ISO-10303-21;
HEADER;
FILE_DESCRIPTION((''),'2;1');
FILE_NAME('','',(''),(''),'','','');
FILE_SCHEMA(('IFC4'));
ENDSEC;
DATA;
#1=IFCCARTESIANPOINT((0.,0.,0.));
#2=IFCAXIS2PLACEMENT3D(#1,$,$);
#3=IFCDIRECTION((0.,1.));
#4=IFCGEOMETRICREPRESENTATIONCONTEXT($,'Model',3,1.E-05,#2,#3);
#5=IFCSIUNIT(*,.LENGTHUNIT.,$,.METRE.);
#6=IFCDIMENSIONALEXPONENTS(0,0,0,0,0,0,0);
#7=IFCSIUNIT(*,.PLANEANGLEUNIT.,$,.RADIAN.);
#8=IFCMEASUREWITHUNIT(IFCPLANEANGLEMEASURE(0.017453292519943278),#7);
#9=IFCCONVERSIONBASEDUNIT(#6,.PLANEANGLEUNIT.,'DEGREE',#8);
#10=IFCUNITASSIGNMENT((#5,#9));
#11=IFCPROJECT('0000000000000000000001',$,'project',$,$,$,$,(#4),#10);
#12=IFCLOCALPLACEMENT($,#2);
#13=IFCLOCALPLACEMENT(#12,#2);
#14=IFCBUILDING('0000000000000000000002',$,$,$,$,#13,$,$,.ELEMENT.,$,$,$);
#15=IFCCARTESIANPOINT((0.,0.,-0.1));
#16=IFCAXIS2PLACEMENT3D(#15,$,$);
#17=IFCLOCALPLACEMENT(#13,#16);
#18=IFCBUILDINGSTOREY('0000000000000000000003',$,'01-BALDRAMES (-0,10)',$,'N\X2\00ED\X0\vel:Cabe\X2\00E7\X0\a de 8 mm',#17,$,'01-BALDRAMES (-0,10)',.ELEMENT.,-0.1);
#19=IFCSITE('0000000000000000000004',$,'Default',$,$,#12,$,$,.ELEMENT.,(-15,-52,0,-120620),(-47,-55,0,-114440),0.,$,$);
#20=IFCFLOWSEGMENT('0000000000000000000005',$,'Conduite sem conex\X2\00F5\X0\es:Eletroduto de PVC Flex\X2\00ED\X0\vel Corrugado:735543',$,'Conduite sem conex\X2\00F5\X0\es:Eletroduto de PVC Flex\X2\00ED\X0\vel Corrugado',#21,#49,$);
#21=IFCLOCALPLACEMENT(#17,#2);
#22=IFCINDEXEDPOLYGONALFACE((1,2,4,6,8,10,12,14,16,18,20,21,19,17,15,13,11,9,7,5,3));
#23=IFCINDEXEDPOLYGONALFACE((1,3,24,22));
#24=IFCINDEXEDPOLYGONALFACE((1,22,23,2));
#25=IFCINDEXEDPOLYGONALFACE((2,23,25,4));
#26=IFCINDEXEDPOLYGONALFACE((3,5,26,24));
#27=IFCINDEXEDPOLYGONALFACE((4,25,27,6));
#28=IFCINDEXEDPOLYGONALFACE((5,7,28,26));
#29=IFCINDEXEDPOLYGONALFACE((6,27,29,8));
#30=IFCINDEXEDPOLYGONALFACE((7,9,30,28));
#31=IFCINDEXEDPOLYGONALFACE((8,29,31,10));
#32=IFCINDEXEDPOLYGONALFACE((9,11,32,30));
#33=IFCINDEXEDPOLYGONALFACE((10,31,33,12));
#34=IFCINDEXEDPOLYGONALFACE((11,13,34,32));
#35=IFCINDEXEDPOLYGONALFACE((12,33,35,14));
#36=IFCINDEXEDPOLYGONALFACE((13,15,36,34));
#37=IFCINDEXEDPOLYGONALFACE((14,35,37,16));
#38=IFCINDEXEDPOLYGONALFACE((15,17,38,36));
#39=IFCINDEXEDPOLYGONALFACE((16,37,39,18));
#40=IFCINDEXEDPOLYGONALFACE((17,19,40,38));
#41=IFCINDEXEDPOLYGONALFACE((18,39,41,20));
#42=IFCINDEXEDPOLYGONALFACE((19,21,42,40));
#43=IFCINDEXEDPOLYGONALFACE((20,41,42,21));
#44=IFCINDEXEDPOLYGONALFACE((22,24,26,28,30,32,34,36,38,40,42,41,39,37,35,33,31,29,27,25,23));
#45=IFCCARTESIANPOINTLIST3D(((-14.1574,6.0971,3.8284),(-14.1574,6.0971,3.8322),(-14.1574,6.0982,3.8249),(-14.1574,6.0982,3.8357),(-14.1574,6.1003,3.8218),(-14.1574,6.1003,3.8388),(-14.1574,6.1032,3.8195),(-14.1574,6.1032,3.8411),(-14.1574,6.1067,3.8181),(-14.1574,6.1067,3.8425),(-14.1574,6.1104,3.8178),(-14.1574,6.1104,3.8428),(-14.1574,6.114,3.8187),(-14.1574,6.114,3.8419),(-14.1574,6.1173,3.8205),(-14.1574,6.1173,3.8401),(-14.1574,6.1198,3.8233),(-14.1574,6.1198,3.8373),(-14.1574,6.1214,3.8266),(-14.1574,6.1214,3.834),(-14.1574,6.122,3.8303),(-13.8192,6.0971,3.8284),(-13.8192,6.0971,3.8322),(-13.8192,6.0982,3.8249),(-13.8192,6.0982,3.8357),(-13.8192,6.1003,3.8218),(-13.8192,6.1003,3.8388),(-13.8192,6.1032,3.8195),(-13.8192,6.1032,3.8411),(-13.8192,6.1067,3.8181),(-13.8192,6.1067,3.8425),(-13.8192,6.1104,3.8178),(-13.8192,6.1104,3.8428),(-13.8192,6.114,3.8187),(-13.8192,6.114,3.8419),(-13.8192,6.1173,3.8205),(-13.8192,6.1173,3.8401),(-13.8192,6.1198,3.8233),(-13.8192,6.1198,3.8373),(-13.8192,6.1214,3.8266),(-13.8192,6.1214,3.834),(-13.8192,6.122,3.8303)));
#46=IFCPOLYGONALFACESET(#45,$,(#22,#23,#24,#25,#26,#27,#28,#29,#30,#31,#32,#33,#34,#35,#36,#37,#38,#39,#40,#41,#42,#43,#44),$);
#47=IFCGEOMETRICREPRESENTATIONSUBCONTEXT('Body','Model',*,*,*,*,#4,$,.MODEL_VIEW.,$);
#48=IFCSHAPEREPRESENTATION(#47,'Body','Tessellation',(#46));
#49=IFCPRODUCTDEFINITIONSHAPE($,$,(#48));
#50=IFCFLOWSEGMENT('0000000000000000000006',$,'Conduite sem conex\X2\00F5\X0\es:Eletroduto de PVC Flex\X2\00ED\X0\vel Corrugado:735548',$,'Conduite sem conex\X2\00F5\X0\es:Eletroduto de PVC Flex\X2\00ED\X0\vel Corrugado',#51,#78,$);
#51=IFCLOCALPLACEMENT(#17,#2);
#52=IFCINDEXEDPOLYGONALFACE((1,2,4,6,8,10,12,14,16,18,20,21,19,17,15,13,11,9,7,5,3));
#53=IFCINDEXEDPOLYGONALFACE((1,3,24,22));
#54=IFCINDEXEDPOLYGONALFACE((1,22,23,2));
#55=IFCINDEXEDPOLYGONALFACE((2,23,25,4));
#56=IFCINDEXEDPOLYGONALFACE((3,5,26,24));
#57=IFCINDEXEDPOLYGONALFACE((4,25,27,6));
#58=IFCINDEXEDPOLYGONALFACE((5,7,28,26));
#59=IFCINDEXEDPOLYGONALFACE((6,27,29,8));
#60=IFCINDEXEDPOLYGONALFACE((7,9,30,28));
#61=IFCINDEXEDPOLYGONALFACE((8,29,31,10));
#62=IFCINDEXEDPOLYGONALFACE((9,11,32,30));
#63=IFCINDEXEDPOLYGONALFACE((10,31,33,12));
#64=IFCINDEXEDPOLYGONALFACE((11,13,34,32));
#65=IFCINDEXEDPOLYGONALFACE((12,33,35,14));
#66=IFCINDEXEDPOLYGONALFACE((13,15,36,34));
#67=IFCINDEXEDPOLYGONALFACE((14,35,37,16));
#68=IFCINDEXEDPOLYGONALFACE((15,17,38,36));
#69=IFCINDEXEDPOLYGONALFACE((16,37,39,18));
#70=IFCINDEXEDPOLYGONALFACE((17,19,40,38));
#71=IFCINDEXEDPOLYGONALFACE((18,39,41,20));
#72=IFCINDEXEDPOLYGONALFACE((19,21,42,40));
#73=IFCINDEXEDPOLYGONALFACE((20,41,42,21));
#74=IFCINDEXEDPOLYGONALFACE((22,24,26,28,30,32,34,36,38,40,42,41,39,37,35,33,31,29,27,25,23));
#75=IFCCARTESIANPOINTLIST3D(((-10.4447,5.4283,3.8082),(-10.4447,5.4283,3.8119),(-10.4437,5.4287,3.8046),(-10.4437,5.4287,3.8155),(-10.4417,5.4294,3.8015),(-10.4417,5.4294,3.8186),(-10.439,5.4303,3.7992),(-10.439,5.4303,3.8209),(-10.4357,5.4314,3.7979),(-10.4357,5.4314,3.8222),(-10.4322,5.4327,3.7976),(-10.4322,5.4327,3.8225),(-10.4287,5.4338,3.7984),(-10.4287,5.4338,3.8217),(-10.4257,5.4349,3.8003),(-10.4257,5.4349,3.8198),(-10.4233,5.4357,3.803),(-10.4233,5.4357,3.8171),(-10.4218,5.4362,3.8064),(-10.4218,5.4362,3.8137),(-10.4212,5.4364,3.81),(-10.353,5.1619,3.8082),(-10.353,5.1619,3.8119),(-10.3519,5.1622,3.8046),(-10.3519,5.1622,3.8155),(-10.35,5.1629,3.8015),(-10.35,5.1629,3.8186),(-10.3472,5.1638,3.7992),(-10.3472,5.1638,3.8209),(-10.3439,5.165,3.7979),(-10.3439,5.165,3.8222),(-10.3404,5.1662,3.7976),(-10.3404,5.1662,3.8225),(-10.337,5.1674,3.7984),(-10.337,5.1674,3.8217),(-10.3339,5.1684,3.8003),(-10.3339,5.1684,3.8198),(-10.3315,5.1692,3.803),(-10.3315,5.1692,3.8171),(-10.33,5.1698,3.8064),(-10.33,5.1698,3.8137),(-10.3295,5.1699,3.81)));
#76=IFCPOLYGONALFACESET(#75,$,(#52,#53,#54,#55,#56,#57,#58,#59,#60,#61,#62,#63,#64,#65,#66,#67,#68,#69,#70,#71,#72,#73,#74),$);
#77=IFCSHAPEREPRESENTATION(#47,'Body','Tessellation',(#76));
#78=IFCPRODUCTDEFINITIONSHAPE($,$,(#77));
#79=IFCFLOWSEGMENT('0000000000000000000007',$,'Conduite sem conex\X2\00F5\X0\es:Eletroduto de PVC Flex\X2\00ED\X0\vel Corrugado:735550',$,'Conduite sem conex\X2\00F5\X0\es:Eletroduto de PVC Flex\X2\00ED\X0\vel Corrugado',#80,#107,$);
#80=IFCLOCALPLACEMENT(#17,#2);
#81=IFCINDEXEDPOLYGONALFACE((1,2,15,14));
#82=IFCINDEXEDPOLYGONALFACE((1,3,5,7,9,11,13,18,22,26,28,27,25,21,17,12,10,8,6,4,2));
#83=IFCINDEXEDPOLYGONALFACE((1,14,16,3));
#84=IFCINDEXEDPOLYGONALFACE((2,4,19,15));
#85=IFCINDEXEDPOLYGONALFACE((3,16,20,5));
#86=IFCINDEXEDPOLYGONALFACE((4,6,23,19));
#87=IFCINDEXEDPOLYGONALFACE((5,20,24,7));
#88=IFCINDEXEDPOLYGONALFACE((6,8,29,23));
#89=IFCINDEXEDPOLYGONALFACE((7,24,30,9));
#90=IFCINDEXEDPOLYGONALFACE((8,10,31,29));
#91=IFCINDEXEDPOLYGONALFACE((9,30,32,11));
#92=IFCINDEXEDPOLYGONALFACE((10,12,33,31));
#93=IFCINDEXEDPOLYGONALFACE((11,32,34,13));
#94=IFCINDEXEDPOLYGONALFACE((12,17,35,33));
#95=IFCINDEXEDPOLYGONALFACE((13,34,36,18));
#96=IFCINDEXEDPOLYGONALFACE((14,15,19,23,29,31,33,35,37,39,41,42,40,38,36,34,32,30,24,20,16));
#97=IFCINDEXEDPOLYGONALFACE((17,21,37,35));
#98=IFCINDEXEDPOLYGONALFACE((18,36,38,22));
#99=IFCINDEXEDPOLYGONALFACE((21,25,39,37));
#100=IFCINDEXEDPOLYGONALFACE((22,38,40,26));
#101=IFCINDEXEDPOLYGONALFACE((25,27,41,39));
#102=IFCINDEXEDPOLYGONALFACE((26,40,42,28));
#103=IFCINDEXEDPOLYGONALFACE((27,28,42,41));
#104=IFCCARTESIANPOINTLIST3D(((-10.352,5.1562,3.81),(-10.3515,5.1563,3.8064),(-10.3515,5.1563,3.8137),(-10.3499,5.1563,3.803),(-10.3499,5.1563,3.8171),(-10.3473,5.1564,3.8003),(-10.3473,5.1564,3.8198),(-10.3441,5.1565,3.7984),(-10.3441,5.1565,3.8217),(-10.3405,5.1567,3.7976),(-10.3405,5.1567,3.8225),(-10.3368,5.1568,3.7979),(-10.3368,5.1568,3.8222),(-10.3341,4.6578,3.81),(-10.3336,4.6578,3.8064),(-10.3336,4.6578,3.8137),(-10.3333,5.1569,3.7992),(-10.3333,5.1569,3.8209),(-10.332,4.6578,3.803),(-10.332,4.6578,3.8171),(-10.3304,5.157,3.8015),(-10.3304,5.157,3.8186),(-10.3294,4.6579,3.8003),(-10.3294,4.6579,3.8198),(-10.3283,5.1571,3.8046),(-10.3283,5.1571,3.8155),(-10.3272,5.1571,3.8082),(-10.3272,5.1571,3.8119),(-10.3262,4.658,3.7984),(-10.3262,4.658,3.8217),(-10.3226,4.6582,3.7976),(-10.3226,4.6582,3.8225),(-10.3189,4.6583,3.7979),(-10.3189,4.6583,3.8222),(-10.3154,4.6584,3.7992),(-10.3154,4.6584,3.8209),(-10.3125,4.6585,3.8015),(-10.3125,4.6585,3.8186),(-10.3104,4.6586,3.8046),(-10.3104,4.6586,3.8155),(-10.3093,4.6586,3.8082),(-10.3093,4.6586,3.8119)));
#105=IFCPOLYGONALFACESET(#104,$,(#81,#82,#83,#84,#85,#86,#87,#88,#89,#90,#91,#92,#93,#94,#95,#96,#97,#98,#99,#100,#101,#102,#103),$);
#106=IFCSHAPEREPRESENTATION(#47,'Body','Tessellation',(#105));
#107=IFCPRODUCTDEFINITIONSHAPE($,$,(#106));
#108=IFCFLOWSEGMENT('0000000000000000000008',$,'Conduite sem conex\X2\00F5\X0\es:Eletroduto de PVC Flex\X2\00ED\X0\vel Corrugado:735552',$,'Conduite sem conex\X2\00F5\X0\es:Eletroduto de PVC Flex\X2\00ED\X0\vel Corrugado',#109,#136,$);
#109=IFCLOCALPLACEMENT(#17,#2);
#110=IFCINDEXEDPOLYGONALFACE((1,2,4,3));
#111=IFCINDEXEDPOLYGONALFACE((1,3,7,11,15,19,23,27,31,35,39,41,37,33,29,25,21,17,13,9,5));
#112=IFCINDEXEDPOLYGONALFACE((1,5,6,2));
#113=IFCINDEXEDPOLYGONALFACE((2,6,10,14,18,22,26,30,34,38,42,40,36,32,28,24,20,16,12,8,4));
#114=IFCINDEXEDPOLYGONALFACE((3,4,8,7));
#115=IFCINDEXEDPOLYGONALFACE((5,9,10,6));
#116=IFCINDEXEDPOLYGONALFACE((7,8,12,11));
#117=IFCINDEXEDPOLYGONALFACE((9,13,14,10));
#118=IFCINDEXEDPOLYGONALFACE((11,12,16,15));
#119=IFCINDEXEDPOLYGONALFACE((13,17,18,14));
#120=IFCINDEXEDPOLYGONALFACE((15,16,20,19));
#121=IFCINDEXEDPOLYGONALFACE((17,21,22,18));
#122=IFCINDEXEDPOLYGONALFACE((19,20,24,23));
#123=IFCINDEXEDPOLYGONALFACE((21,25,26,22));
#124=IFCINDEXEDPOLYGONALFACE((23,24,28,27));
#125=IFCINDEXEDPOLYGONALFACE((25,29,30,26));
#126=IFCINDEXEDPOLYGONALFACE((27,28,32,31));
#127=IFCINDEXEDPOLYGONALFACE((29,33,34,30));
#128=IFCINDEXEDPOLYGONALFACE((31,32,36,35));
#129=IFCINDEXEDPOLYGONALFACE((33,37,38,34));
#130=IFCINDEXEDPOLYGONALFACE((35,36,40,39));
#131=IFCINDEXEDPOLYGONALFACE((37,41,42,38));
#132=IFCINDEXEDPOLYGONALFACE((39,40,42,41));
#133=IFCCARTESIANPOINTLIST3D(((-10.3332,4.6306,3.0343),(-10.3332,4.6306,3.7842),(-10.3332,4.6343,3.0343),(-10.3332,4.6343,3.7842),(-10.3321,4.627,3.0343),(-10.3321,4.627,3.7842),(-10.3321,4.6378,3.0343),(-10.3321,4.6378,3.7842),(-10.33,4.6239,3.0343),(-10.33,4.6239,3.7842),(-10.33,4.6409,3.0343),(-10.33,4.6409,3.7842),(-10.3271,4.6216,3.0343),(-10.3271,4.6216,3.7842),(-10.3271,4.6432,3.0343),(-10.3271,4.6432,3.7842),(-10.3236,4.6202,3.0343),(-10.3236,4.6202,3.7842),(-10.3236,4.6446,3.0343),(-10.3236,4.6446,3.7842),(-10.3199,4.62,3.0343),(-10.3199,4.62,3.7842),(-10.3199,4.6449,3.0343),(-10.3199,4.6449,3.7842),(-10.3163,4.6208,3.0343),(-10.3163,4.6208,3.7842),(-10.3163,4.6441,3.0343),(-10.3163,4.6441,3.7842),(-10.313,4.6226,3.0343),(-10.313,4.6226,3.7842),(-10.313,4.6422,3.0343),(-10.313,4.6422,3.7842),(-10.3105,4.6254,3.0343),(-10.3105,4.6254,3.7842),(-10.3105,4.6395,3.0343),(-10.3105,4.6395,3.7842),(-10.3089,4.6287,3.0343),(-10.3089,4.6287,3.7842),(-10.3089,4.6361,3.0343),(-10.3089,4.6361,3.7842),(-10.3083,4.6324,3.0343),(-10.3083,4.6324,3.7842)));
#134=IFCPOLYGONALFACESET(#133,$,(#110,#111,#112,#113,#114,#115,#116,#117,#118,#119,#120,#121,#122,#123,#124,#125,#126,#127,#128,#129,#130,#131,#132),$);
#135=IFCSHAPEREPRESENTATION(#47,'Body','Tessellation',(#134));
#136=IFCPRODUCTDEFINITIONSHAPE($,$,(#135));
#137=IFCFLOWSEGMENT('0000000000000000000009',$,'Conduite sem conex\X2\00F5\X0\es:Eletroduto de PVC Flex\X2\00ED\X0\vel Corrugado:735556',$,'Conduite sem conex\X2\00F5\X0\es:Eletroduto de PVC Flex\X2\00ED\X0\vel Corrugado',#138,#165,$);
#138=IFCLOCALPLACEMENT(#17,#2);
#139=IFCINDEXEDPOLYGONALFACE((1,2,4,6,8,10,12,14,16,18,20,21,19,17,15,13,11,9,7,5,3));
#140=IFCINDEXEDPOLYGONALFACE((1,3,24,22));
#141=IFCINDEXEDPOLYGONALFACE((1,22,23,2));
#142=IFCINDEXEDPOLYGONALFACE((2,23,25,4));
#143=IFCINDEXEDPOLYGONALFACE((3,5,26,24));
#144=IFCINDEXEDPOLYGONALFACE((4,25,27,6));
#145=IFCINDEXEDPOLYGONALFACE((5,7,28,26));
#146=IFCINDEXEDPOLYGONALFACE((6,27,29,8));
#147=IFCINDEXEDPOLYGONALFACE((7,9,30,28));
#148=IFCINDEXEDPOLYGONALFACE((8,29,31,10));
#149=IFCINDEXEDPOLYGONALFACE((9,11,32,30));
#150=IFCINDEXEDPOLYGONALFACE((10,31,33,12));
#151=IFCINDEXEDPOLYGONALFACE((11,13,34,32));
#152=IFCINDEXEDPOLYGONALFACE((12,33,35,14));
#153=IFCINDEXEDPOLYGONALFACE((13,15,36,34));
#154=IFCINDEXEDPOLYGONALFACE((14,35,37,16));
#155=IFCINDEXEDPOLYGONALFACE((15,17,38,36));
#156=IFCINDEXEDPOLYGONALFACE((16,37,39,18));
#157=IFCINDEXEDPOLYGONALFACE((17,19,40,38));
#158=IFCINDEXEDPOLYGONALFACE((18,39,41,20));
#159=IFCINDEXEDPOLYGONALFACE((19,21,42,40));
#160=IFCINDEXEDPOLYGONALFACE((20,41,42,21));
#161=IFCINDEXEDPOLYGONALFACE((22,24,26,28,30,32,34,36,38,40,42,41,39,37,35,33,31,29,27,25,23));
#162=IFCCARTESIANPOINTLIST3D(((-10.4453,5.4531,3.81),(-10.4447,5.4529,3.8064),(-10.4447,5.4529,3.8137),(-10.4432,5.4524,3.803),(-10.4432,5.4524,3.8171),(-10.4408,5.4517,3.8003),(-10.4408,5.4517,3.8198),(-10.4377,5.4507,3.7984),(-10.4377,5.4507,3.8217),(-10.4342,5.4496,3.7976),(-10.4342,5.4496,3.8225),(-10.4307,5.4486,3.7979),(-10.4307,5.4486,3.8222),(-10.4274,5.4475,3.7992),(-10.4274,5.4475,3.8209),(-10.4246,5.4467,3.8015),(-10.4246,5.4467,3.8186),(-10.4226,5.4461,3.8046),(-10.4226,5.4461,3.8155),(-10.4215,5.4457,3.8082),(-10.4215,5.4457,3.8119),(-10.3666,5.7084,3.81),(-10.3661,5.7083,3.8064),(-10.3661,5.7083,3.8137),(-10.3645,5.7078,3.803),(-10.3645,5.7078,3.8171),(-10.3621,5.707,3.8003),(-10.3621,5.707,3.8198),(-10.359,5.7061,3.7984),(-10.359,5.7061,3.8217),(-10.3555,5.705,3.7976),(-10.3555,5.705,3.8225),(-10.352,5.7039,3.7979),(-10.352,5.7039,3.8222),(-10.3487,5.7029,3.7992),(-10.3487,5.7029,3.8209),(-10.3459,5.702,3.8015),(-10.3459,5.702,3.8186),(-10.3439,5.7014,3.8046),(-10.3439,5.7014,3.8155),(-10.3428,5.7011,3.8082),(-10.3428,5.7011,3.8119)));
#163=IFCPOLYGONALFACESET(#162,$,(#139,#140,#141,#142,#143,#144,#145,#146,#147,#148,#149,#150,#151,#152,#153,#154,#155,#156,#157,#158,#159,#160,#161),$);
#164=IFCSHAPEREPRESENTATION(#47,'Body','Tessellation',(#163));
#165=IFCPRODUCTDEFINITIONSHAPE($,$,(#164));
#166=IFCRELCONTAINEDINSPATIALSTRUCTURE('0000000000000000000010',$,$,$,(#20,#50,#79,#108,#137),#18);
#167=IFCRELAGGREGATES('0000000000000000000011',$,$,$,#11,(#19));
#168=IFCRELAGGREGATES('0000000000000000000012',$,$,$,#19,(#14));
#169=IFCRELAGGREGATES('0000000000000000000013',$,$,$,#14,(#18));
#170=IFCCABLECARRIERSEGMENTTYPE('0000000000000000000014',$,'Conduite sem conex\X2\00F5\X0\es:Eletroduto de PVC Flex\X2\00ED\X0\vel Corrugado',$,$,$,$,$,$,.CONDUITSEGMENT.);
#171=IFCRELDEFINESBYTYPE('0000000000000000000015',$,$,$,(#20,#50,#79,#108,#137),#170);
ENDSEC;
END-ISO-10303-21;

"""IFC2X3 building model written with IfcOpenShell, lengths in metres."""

from ifc_helpers import new_model, entity, si_unit, converted_unit, direction, frame, frame_2d, origin, origin_2d_with_axis, place, context, subcontext, project, spatial, circle, extrude, type_object, element, save


model = new_model("IFC2X3")

# Units and contexts
model_context = context("Model", 3, precision=1e-05, world=origin(), true_north=direction((0.0, 1.0)))
body_context = subcontext(model_context, "Body", "Model", "MODEL_VIEW")
ifc_project = project(units=[si_unit("LENGTHUNIT", "METRE"), converted_unit("PLANEANGLEUNIT", "DEGREE", entity("IfcPlaneAngleMeasure", 0.017453292519943278), si_unit("PLANEANGLEUNIT", "RADIAN"), dimensions=[0, 0, 0, 0, 0, 0, 0])], contexts=[model_context])

# Site, building, storey
site_placement = place(None, origin())
site = spatial("IfcSite", under=ifc_project, at=site_placement, Name="Default", CompositionType="ELEMENT", RefLatitude=(-15, -52, 0, -120620), RefLongitude=(-47, -55, 0, -114440), RefElevation=0.0)
building_placement = place(site_placement, origin())
building = spatial("IfcBuilding", under=site, at=building_placement, CompositionType="ELEMENT")
storey_placement = place(building_placement, frame((0.0, 0.0, -0.1)))
storey = spatial("IfcBuildingStorey", under=building, at=storey_placement, Name="01-BALDRAMES (-0,10)", ObjectType="Nível:Cabeça de 8 mm", LongName="01-BALDRAMES (-0,10)", CompositionType="ELEMENT", Elevation=-0.1)

# Flow segments
cable_carrier_segment_type = type_object("IfcCableCarrierSegmentType", Name="Conduite sem conexões:Eletroduto de PVC Flexível Corrugado", PredefinedType="CONDUITSEGMENT")
flow_segment_1_placement = place(storey_placement, origin())
element("IfcFlowSegment", 1, at=flow_segment_1_placement, inside=storey, type_object=cable_carrier_segment_type, Name="Conduite sem conexões:Eletroduto de PVC Flexível Corrugado:735543", ObjectType="Conduite sem conexões:Eletroduto de PVC Flexível Corrugado", context=body_context, shape_type="SweptSolid", body=[
    extrude(circle(Radius=0.0125, at=frame_2d((0.0, 0.0), x_axis=(1.0, 0.0))), frame((-14.1574, 6.1095, 3.8303), z_axis=(1.0, 0.0, 0.0), x_axis=(0.0, 1.0, 0.0)), (0.0, 0.0, 1.0), 0.3382),
])
flow_segment_2_placement = place(storey_placement, origin())
element("IfcFlowSegment", 2, at=flow_segment_2_placement, inside=storey, type_object=cable_carrier_segment_type, Name="Conduite sem conexões:Eletroduto de PVC Flexível Corrugado:735548", ObjectType="Conduite sem conexões:Eletroduto de PVC Flexível Corrugado", context=body_context, shape_type="SweptSolid", body=[
    extrude(circle(Radius=0.0125, at=origin_2d_with_axis()), frame((-10.3413, 5.1659, 3.81), z_axis=(-0.325568, 0.945519, 0.0), x_axis=(0.945519, 0.325568, 0.0)), (0.0, 0.0, 1.0), 0.2818),
])
flow_segment_3_placement = place(storey_placement, origin())
element("IfcFlowSegment", 3, at=flow_segment_3_placement, inside=storey, type_object=cable_carrier_segment_type, Name="Conduite sem conexões:Eletroduto de PVC Flexível Corrugado:735550", ObjectType="Conduite sem conexões:Eletroduto de PVC Flexível Corrugado", context=body_context, shape_type="SweptSolid", body=[
    extrude(circle(Radius=0.0125, at=origin_2d_with_axis()), frame((-10.3396, 5.1567, 3.81), z_axis=(0.035898, -0.999355, 0.0), x_axis=(-0.999355, -0.035898, 0.0)), (0.0, 0.0, 1.0), 0.4988),
])
flow_segment_4_placement = place(storey_placement, origin())
element("IfcFlowSegment", 4, at=flow_segment_4_placement, inside=storey, type_object=cable_carrier_segment_type, Name="Conduite sem conexões:Eletroduto de PVC Flexível Corrugado:735552", ObjectType="Conduite sem conexões:Eletroduto de PVC Flexível Corrugado", context=body_context, shape_type="SweptSolid", body=[
    extrude(circle(Radius=0.0125, at=origin_2d_with_axis()), frame((-10.3208, 4.6324, 3.0343)), (0.0, 0.0, 1.0), 0.75),
])
flow_segment_5_placement = place(storey_placement, origin())
element("IfcFlowSegment", 5, at=flow_segment_5_placement, inside=storey, type_object=cable_carrier_segment_type, Name="Conduite sem conexões:Eletroduto de PVC Flexível Corrugado:735556", ObjectType="Conduite sem conexões:Eletroduto de PVC Flexível Corrugado", context=body_context, shape_type="SweptSolid", body=[
    extrude(circle(Radius=0.0125, at=origin_2d_with_axis()), frame((-10.4333, 5.4494, 3.81), z_axis=(0.294435, 0.955672, 0.0), x_axis=(-0.955672, 0.294435, 0.0)), (0.0, 0.0, 1.0), 0.2672),
])

save(model, "model.ifc")
